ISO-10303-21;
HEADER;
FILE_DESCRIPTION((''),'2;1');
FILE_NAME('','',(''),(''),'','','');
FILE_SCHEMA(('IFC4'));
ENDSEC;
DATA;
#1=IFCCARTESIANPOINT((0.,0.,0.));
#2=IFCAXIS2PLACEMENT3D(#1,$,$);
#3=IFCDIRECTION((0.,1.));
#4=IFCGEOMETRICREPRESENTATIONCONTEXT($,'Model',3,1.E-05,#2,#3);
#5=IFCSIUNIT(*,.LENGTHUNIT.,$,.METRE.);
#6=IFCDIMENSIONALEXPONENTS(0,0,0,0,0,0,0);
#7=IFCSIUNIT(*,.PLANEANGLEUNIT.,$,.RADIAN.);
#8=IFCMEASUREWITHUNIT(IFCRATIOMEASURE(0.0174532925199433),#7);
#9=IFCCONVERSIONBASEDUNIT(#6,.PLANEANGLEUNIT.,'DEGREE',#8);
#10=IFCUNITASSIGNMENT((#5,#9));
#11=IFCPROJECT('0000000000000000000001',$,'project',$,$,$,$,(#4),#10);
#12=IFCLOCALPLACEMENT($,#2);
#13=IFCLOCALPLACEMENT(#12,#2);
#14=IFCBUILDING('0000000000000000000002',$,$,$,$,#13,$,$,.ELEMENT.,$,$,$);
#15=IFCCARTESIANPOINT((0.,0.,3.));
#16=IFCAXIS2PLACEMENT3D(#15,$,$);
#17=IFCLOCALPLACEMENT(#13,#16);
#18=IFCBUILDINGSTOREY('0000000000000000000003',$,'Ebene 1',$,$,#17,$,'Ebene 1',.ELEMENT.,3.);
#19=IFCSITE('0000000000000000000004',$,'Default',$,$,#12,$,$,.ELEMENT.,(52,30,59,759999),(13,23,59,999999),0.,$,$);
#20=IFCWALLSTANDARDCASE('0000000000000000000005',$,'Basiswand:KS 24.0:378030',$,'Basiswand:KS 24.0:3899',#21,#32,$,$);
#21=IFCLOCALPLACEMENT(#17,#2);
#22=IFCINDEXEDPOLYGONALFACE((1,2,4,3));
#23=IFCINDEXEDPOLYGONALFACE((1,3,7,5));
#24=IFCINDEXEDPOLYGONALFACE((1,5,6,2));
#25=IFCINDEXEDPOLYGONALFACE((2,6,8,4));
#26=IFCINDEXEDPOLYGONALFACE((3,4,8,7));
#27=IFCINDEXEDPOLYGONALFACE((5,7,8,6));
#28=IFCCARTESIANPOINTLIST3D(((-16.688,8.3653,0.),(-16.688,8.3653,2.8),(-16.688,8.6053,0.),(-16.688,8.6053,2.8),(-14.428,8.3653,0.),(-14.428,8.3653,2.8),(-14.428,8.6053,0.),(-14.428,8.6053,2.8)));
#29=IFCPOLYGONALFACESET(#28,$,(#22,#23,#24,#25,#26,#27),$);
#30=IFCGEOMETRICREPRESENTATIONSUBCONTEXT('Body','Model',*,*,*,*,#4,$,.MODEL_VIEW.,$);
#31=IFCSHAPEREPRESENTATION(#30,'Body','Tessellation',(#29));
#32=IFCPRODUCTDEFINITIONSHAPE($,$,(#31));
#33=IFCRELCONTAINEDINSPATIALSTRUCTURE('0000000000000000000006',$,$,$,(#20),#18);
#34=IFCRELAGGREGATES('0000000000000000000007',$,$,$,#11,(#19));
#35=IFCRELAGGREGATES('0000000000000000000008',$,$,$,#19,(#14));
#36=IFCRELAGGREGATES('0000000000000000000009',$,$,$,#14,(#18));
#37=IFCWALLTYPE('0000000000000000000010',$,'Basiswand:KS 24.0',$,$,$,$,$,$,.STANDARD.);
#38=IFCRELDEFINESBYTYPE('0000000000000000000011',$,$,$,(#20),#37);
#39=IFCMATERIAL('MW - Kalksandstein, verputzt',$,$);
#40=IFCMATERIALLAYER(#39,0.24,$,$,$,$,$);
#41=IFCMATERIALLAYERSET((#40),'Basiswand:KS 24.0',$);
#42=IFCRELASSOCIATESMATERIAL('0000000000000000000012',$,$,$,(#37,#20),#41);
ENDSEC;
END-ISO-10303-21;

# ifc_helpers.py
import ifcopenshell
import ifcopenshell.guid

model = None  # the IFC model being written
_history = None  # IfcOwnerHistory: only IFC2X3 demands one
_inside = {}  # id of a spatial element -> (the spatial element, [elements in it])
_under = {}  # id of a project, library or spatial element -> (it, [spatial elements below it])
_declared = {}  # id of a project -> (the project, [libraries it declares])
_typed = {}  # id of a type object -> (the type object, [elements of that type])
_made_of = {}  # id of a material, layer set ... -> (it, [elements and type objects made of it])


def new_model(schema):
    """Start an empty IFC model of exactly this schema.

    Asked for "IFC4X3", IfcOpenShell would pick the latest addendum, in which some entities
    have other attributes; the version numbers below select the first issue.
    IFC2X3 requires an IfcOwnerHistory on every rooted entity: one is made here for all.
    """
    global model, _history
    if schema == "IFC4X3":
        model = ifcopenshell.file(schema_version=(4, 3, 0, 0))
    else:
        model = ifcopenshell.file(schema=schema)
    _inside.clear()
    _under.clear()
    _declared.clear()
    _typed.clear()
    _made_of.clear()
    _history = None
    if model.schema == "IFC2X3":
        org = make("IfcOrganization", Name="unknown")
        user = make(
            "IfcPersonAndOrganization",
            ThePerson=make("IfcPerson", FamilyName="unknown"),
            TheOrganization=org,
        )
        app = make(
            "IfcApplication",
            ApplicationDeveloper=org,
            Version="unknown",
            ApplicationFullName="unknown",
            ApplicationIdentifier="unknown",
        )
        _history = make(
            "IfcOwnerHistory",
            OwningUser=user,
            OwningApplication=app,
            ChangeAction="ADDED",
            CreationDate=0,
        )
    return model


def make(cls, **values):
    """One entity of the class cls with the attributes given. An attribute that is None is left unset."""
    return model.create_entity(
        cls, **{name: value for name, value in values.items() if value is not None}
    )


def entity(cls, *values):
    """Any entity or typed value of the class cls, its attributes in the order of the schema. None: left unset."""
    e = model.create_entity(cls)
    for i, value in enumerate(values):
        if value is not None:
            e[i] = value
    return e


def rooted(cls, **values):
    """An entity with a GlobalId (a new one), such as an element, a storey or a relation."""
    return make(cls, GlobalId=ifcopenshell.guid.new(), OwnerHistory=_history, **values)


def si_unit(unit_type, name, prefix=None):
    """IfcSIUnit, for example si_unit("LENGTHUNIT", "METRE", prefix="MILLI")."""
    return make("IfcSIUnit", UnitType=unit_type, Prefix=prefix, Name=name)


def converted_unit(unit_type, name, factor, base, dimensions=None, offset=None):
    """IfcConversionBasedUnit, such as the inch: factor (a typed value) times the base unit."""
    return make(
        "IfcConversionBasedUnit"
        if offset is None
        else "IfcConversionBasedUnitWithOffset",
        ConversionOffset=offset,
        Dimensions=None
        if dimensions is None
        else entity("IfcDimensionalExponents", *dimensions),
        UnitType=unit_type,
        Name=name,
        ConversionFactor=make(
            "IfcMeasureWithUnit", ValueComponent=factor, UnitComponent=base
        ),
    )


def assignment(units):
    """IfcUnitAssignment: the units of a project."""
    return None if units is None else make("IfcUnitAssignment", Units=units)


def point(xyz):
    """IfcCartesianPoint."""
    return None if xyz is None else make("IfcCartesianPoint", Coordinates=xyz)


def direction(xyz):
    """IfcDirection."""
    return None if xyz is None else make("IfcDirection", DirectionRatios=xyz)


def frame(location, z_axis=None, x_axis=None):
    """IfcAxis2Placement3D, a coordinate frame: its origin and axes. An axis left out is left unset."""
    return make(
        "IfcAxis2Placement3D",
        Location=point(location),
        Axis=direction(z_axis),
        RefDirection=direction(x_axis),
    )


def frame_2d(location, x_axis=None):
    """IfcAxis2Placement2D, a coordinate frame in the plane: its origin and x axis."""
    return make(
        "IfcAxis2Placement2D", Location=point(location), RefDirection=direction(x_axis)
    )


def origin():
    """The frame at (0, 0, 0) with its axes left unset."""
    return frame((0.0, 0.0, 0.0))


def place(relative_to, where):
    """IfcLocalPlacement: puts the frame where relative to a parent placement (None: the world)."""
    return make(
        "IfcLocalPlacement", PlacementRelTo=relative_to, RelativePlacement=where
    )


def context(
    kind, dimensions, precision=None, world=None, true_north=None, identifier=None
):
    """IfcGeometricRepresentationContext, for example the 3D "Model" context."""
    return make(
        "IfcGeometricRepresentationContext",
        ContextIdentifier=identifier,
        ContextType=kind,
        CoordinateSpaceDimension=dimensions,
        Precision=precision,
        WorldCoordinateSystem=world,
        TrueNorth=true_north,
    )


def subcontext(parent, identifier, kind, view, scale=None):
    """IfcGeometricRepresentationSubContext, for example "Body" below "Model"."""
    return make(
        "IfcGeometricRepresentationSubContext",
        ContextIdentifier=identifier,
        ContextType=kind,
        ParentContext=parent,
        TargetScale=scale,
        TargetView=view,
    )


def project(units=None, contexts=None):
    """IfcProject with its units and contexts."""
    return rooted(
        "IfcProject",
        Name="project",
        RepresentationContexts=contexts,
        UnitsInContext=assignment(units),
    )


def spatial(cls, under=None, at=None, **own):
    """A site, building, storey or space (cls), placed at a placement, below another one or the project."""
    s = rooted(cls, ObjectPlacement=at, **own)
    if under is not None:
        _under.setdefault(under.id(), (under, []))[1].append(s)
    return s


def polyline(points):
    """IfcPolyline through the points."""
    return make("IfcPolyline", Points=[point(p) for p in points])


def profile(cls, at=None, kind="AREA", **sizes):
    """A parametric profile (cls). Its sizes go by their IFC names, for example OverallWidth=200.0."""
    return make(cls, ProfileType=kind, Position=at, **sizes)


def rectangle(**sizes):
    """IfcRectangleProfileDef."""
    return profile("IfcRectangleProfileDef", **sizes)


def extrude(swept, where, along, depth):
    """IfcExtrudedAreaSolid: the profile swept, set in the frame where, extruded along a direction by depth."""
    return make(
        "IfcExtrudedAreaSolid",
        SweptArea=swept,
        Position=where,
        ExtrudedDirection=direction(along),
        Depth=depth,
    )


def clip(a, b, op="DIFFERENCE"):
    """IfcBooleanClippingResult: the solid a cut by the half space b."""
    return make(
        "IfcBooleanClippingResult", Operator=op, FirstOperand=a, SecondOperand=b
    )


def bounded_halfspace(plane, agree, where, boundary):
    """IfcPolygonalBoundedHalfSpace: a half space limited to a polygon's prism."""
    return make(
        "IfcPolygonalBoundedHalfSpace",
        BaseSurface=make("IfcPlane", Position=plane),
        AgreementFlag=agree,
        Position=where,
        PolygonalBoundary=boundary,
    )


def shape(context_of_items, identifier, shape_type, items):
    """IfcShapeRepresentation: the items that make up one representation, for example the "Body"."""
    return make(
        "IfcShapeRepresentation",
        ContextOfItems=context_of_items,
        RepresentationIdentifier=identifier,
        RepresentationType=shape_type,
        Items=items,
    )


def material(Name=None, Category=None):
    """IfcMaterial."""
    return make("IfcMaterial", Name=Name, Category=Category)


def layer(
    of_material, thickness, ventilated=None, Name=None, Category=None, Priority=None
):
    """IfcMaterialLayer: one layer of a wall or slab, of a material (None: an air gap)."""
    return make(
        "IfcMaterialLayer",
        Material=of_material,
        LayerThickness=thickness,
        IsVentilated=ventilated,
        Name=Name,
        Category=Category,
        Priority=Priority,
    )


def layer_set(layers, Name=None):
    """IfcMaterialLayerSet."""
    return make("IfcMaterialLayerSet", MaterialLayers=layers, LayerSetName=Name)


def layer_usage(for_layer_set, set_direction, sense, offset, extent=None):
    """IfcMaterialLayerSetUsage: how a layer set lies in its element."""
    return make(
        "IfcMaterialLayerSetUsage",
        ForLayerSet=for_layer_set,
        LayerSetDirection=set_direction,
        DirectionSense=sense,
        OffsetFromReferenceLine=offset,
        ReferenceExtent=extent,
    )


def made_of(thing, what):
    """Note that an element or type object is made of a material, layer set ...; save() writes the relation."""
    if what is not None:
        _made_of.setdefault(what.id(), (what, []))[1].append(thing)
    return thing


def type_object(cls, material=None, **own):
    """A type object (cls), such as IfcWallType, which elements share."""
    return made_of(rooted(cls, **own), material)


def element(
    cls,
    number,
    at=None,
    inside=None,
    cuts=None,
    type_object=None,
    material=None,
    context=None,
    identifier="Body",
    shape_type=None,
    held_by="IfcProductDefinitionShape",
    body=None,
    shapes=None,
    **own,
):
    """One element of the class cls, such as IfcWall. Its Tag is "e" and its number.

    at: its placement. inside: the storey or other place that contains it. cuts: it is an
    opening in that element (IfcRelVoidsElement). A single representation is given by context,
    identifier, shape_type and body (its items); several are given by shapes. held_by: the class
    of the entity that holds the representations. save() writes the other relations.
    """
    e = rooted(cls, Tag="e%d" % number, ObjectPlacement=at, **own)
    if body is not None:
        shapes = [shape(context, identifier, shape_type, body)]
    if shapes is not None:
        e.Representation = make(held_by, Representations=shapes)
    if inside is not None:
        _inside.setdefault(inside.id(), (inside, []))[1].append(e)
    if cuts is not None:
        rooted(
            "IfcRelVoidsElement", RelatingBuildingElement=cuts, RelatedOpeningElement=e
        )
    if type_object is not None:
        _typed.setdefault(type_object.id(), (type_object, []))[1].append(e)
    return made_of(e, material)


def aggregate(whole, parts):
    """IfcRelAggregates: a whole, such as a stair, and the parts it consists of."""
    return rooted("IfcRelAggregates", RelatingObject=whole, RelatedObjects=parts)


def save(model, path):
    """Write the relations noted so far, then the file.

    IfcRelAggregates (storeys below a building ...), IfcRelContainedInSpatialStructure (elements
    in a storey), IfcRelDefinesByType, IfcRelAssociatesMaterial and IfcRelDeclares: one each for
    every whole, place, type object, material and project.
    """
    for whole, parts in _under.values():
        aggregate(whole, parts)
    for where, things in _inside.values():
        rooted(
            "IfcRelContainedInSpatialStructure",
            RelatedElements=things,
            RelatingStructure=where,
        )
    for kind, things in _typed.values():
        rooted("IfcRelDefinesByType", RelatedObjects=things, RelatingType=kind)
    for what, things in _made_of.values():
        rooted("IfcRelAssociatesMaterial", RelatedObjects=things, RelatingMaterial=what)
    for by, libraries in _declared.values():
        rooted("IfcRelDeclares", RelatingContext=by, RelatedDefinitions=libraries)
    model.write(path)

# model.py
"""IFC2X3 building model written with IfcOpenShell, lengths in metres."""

from ifc_helpers import new_model, entity, si_unit, converted_unit, direction, frame, frame_2d, origin, place, context, subcontext, project, spatial, polyline, rectangle, extrude, clip, bounded_halfspace, material, layer, layer_set, layer_usage, type_object, element, save


model = new_model("IFC2X3")

# Units and contexts
model_context = context("Model", 3, precision=1e-05, world=origin(), true_north=direction((0.0, 1.0)))
body_context = subcontext(model_context, "Body", "Model", "MODEL_VIEW")
ifc_project = project(units=[si_unit("LENGTHUNIT", "METRE"), converted_unit("PLANEANGLEUNIT", "DEGREE", entity("IfcRatioMeasure", 0.0174532925199433), si_unit("PLANEANGLEUNIT", "RADIAN"), dimensions=[0, 0, 0, 0, 0, 0, 0])], contexts=[model_context])

# Site, building, storey
site_placement = place(None, origin())
site = spatial("IfcSite", under=ifc_project, at=site_placement, Name="Default", CompositionType="ELEMENT", RefLatitude=(52, 30, 59, 759999), RefLongitude=(13, 23, 59, 999999), RefElevation=0.0)
building_placement = place(site_placement, origin())
building = spatial("IfcBuilding", under=site, at=building_placement, CompositionType="ELEMENT")
storey_placement = place(building_placement, frame((0.0, 0.0, 3.0)))
storey = spatial("IfcBuildingStorey", under=building, at=storey_placement, Name="Ebene 1", LongName="Ebene 1", CompositionType="ELEMENT", Elevation=3.0)

# Shared definitions
ifc_material_1 = material(Name="MW - Kalksandstein, verputzt")
ifc_layer_1 = layer(ifc_material_1, 0.24)
ifc_layer_set_1 = layer_set([ifc_layer_1], Name="Basiswand:KS 24.0")
wall_type_1 = type_object("IfcWallType", Name="Basiswand:KS 24.0", PredefinedType="STANDARD", material=ifc_layer_set_1)

# Wall
ifc_layer_usage_1 = layer_usage(ifc_layer_set_1, "AXIS2", "NEGATIVE", 0.12)
wall_1_placement = place(storey_placement, frame((-16.688, 8.4853, 0.0)))
element("IfcWallStandardCase", 1, at=wall_1_placement, inside=storey, type_object=wall_type_1, material=ifc_layer_usage_1, Name="Basiswand:KS 24.0:378030", ObjectType="Basiswand:KS 24.0:3899", context=body_context, shape_type="Clipping", body=[
    clip(extrude(rectangle(XDim=2.26, YDim=0.24, at=frame_2d((1.13, 0.0), x_axis=(-1.0, 0.0))), origin(), (0.0, 0.0, 1.0), 2.8), bounded_halfspace(frame((0.0, -0.12, 2.8), z_axis=(0.0, 0.0, -1.0), x_axis=(-1.0, 0.0, 0.0)), True, frame((0.0, -0.12, 2.8)), polyline([(0.0, 0.0), (2.26, 0.0), (2.26, 0.24), (0.0, 0.24), (0.0, 0.0)]))),
])

save(model, "model.ifc")
